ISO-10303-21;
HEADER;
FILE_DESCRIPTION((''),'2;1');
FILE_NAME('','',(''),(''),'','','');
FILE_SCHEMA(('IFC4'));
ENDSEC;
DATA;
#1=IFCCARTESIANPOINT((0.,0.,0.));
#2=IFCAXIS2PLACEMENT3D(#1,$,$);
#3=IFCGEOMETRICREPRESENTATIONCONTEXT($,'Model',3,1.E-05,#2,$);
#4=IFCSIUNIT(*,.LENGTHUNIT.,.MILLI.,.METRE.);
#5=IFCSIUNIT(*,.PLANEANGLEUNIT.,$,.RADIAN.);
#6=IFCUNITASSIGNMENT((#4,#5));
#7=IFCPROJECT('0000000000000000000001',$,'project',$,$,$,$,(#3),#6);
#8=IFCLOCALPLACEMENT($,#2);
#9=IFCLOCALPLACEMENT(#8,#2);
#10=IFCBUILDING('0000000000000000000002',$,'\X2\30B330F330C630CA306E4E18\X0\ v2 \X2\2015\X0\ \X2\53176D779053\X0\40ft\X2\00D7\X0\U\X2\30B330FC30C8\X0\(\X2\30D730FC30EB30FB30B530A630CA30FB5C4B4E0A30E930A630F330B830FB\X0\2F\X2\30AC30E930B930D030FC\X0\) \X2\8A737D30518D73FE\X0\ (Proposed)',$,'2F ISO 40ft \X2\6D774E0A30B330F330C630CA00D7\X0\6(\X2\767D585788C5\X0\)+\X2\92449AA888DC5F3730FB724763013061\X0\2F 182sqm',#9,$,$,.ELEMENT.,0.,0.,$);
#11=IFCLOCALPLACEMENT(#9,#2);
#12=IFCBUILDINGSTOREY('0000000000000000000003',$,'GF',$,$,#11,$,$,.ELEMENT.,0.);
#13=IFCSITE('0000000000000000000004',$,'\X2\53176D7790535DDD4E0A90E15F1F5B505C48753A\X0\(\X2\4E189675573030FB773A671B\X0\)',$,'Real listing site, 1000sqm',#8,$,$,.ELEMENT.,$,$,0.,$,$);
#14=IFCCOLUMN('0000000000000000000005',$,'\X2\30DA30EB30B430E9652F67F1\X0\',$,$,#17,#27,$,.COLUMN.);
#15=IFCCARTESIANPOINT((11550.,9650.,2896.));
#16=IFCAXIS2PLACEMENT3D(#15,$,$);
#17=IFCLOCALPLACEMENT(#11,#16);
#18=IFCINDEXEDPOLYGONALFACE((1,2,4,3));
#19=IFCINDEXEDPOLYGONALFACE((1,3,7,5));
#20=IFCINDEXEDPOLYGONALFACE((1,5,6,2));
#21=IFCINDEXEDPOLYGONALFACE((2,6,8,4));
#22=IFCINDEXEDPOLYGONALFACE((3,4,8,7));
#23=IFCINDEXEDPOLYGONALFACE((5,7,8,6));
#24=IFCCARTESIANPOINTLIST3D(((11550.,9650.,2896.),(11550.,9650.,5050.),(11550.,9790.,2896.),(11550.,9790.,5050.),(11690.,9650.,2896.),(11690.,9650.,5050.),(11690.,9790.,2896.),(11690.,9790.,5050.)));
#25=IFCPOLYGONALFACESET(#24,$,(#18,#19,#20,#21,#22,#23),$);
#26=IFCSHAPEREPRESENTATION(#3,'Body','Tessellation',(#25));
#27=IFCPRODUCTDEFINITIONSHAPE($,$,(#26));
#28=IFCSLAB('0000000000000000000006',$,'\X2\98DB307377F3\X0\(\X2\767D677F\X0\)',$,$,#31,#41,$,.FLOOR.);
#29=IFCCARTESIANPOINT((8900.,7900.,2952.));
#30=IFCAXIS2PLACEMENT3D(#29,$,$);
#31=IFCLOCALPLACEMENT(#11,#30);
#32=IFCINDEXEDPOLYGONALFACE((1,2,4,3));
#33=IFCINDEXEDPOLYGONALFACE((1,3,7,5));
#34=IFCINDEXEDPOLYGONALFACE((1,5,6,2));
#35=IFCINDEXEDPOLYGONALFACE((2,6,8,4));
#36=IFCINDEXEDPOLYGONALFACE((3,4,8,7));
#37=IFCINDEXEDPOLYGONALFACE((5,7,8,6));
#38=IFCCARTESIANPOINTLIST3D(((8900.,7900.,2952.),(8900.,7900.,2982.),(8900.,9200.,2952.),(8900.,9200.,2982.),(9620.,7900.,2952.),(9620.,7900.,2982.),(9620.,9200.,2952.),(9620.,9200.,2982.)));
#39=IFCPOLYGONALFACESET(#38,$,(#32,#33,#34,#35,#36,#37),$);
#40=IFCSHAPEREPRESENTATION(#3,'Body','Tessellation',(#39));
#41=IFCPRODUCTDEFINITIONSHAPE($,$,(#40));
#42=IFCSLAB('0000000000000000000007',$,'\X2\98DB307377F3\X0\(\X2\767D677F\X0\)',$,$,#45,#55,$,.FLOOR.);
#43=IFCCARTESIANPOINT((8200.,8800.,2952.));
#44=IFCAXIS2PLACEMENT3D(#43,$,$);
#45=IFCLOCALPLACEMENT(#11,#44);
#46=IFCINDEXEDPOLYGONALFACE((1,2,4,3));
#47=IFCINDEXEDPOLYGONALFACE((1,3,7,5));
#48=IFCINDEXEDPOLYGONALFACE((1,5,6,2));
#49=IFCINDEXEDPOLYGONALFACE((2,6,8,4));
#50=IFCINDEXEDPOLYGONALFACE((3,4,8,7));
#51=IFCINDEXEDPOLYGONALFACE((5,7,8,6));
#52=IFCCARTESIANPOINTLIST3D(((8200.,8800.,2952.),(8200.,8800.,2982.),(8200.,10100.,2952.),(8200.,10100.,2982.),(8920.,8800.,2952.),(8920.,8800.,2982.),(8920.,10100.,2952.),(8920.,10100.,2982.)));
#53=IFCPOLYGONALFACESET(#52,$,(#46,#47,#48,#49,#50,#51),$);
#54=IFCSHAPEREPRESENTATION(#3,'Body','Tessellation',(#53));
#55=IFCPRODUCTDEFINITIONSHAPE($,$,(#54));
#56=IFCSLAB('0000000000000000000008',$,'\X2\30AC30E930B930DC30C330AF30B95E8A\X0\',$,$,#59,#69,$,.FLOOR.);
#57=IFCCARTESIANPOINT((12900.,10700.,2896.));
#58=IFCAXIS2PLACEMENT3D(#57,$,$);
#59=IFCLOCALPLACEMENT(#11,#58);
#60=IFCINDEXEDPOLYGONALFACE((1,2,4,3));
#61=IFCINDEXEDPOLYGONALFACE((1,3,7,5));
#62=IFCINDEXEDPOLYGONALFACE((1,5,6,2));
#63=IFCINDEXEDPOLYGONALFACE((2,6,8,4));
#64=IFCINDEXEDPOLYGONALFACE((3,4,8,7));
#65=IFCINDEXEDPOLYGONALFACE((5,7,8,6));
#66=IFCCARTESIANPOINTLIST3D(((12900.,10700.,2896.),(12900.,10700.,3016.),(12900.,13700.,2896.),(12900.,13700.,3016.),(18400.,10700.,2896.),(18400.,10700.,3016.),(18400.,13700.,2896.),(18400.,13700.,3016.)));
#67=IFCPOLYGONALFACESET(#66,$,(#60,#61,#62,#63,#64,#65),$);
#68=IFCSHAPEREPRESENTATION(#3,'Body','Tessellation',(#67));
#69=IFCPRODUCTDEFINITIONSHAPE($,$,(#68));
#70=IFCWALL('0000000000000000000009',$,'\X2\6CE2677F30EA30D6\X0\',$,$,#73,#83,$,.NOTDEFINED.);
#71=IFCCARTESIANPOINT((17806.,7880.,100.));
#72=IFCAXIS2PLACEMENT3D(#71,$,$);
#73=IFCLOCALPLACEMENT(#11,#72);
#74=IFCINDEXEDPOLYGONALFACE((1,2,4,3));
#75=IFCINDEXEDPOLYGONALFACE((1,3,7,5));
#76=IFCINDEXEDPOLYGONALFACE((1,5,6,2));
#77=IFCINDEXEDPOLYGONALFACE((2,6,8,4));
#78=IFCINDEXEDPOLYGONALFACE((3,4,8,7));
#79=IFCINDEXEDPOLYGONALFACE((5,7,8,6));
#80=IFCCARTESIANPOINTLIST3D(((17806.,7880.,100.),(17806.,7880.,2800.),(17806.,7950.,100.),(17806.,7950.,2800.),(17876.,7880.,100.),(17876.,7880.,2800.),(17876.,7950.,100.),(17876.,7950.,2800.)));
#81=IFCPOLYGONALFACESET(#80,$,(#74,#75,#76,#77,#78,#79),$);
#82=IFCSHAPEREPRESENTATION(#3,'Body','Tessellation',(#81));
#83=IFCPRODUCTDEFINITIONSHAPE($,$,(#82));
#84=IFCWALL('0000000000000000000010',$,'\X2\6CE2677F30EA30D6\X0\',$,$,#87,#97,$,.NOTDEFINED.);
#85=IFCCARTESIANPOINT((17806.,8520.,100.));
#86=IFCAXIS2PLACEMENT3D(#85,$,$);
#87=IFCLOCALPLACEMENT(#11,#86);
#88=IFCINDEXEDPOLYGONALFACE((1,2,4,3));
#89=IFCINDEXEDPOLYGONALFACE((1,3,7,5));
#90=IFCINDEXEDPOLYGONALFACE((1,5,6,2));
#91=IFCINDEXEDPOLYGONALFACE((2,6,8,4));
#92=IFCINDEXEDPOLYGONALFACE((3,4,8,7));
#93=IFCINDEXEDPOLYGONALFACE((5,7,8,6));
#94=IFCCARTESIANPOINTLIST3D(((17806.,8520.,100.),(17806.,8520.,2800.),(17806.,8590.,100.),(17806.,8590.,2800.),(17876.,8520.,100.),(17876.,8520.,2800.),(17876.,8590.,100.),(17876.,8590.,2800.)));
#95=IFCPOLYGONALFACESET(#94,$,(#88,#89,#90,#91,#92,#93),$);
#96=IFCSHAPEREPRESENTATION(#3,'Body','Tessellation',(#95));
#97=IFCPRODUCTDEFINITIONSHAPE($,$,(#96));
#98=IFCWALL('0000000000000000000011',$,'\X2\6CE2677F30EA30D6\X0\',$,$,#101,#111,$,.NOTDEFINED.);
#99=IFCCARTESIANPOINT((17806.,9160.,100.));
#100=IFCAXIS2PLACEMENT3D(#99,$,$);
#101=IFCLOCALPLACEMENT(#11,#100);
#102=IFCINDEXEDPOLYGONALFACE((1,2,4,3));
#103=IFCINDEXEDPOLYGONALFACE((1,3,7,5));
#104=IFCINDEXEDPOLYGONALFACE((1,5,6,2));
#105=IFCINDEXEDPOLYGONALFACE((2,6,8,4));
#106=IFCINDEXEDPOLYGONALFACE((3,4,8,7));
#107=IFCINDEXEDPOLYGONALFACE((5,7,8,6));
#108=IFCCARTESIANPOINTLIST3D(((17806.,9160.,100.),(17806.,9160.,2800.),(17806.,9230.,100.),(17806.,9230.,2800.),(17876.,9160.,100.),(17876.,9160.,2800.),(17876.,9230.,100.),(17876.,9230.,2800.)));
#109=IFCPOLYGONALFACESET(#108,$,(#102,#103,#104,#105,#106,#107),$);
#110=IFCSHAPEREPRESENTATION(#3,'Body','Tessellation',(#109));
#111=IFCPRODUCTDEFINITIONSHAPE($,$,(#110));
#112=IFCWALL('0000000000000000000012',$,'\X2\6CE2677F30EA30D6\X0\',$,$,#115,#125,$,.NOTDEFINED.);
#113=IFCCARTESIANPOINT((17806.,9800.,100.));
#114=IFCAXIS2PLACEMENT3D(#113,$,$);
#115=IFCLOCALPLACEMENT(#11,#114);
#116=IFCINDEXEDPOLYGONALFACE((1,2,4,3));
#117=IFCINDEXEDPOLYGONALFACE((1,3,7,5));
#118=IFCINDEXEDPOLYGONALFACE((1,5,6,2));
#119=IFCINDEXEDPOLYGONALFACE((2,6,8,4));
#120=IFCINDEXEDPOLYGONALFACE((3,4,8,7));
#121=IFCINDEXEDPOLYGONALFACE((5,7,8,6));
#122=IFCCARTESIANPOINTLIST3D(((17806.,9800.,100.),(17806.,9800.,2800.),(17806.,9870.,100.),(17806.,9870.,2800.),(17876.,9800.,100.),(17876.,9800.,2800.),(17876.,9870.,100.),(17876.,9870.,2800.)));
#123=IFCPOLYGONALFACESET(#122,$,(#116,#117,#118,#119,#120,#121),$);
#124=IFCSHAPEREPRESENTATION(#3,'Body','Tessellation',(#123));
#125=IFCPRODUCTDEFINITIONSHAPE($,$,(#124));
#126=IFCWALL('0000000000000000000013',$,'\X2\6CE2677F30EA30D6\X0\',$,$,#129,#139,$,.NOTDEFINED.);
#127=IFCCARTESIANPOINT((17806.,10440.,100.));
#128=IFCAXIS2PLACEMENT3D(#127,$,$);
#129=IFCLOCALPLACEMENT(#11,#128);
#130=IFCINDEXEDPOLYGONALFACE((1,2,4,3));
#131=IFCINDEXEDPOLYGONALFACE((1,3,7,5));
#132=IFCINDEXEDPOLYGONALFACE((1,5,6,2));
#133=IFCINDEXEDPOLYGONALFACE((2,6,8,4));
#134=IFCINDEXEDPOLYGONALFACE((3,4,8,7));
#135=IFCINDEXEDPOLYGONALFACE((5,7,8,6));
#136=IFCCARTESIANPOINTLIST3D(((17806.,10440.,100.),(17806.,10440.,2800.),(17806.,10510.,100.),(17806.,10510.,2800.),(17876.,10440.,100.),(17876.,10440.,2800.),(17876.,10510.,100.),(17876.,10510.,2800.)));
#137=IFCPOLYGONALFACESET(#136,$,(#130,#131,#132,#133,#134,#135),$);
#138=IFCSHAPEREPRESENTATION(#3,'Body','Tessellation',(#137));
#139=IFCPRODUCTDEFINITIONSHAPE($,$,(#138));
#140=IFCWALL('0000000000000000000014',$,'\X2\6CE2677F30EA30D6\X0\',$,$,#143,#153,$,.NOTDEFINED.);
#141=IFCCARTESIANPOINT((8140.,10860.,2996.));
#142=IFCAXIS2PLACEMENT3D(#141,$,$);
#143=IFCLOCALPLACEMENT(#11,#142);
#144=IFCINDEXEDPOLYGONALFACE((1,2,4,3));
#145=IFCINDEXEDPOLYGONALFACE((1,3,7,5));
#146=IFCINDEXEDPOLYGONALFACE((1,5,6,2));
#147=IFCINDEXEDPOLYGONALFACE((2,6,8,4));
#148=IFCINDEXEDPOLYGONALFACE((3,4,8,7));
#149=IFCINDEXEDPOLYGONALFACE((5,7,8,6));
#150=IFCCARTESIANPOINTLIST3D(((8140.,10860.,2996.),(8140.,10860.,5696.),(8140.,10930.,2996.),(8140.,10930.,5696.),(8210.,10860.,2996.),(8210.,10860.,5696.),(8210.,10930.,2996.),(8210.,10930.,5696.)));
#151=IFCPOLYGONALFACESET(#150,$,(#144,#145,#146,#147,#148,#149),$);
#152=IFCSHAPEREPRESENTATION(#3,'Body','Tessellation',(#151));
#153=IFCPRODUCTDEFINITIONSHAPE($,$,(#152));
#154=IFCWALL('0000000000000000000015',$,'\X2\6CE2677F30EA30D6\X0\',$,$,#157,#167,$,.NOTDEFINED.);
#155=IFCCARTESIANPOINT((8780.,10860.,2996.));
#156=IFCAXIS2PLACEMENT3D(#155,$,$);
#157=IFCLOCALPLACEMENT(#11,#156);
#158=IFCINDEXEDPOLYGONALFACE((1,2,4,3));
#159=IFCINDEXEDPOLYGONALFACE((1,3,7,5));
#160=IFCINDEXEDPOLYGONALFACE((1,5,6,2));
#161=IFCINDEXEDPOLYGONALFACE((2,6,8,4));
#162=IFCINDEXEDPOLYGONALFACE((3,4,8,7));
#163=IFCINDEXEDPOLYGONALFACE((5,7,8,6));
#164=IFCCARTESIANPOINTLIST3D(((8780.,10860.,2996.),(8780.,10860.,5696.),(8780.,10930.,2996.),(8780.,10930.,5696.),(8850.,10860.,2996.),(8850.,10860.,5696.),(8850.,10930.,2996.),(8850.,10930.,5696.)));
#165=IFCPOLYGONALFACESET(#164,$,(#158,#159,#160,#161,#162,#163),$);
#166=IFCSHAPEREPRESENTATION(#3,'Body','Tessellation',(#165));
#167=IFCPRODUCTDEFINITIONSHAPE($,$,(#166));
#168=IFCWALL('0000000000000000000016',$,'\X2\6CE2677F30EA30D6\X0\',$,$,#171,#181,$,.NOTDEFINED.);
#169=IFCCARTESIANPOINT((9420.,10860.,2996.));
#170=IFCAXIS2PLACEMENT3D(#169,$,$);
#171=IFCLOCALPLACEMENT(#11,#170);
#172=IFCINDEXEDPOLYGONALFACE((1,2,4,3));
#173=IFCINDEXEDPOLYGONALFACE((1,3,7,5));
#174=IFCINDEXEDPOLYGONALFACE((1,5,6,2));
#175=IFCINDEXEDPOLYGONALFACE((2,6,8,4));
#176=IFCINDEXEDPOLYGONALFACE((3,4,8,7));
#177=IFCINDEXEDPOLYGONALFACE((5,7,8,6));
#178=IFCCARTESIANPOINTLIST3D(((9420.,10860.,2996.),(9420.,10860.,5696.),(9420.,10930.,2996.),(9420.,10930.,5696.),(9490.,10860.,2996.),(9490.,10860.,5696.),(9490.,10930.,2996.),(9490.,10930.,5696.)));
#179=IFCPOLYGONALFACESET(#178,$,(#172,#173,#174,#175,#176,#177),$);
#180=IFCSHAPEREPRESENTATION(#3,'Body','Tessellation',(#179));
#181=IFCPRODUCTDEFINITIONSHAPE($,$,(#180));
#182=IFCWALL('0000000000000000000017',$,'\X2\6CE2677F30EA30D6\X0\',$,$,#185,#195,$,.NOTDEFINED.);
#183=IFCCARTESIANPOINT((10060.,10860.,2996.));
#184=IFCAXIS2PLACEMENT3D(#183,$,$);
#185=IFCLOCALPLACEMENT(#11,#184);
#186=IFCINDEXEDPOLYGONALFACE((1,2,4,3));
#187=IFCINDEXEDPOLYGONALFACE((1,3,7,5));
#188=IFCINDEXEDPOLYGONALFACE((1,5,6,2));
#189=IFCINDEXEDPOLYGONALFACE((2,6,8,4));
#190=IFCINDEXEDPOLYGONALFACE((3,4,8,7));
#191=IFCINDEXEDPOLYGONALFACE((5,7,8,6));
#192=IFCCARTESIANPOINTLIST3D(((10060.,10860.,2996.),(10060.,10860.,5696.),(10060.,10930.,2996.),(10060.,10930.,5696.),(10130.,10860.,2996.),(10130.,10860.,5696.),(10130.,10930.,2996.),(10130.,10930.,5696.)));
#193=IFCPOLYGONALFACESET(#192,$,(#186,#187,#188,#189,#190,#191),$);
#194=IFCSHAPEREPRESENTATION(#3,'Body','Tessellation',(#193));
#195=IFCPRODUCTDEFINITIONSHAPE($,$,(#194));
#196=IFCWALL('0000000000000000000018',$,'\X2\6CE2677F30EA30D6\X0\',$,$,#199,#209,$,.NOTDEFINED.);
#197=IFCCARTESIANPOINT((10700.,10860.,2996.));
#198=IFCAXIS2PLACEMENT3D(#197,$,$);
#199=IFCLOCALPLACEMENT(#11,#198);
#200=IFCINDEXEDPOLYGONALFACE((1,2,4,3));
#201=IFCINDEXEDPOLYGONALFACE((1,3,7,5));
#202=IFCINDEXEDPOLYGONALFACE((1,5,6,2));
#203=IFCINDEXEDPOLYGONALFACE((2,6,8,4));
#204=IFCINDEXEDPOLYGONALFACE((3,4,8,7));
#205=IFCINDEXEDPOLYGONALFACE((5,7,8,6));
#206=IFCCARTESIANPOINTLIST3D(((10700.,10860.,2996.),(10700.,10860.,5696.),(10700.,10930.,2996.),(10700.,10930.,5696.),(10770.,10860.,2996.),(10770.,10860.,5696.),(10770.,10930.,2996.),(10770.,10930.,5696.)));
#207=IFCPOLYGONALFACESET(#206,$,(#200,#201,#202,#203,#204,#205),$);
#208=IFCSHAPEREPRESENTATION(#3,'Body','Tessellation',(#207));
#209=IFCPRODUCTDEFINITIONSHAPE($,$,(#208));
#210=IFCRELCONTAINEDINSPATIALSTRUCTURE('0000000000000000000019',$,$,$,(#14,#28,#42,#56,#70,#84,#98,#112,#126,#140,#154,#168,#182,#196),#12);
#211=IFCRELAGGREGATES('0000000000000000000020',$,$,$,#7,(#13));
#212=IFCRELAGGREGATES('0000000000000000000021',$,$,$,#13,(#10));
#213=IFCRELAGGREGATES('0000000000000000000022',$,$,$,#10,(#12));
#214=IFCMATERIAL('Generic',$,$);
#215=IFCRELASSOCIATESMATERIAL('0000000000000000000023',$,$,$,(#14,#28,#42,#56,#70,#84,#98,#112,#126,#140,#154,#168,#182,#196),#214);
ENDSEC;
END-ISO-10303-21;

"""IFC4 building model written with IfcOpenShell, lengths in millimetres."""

from ifc_helpers import new_model, si_unit, frame, frame_2d, origin, place, context, project, spatial, rectangle, extrude, material, element, save


model = new_model("IFC4")

# Units and contexts
model_context = context("Model", 3, precision=1e-05, world=origin())
ifc_project = project(units=[si_unit("LENGTHUNIT", "METRE", prefix="MILLI"), si_unit("PLANEANGLEUNIT", "RADIAN")], contexts=[model_context])

# Site, building, storey
site_placement = place(None, origin())
site = spatial("IfcSite", under=ifc_project, at=site_placement, Name="北海道川上郡弟子屈町(丘陵地・眺望)", ObjectType="Real listing site, 1000sqm", CompositionType="ELEMENT", RefElevation=0.0)
building_placement = place(site_placement, origin())
building = spatial("IfcBuilding", under=site, at=building_placement, Name="コンテナの丘 v2 ― 北海道40ft×Uコート(プール・サウナ・屋上ラウンジ・2Fガラスバー) 詳細再現 (Proposed)", ObjectType="2F ISO 40ft 海上コンテナ×6(白塗装)+鉄骨補強・片持ち2F 182sqm", CompositionType="ELEMENT", ElevationOfRefHeight=0.0, ElevationOfTerrain=0.0)
storey_placement = place(building_placement, origin())
storey = spatial("IfcBuildingStorey", under=building, at=storey_placement, Name="GF", CompositionType="ELEMENT", Elevation=0.0)

# Column
ifc_material = material(Name="Generic")
column_placement = place(storey_placement, frame((11550.0, 9650.0, 2896.0)))
element("IfcColumn", 1, at=column_placement, inside=storey, material=ifc_material, Name="ペルゴラ支柱", PredefinedType="COLUMN", context=model_context, shape_type="SweptSolid", body=[
    extrude(rectangle(XDim=140.0, YDim=140.0, at=frame_2d((70.0, 70.0))), frame((11550.0, 9650.0, 2896.0)), (0.0, 0.0, 1.0), 2154.0),
])

# Slabs
slab_1_placement = place(storey_placement, frame((8900.0, 7900.0, 2952.0)))
element("IfcSlab", 2, at=slab_1_placement, inside=storey, material=ifc_material, Name="飛び石(白板)", PredefinedType="FLOOR", context=model_context, shape_type="SweptSolid", body=[
    extrude(rectangle(XDim=720.0, YDim=1300.0, at=frame_2d((360.0, 650.0))), frame((8900.0, 7900.0, 2952.0)), (0.0, 0.0, 1.0), 30.0),
])
slab_2_placement = place(storey_placement, frame((8200.0, 8800.0, 2952.0)))
element("IfcSlab", 3, at=slab_2_placement, inside=storey, material=ifc_material, Name="飛び石(白板)", PredefinedType="FLOOR", context=model_context, shape_type="SweptSolid", body=[
    extrude(rectangle(XDim=720.0, YDim=1300.0, at=frame_2d((360.0, 650.0))), frame((8200.0, 8800.0, 2952.0)), (0.0, 0.0, 1.0), 30.0),
])
slab_3_placement = place(storey_placement, frame((12900.0, 10700.0, 2896.0)))
element("IfcSlab", 4, at=slab_3_placement, inside=storey, material=ifc_material, Name="ガラスボックス床", PredefinedType="FLOOR", context=model_context, shape_type="SweptSolid", body=[
    extrude(rectangle(XDim=5500.0, YDim=3000.0, at=frame_2d((2750.0, 1500.0))), frame((12900.0, 10700.0, 2896.0)), (0.0, 0.0, 1.0), 120.0),
])

# Walls
wall_1_placement = place(storey_placement, frame((17806.0, 7880.0, 100.0)))
element("IfcWall", 5, at=wall_1_placement, inside=storey, material=ifc_material, Name="波板リブ", PredefinedType="NOTDEFINED", context=model_context, shape_type="SweptSolid", body=[
    extrude(rectangle(XDim=70.0, YDim=70.0, at=frame_2d((35.0, 35.0))), frame((17806.0, 7880.0, 100.0)), (0.0, 0.0, 1.0), 2700.0),
])
wall_2_placement = place(storey_placement, frame((17806.0, 8520.0, 100.0)))
element("IfcWall", 6, at=wall_2_placement, inside=storey, material=ifc_material, Name="波板リブ", PredefinedType="NOTDEFINED", context=model_context, shape_type="SweptSolid", body=[
    extrude(rectangle(XDim=70.0, YDim=70.0, at=frame_2d((35.0, 35.0))), frame((17806.0, 8520.0, 100.0)), (0.0, 0.0, 1.0), 2700.0),
])
wall_3_placement = place(storey_placement, frame((17806.0, 9160.0, 100.0)))
element("IfcWall", 7, at=wall_3_placement, inside=storey, material=ifc_material, Name="波板リブ", PredefinedType="NOTDEFINED", context=model_context, shape_type="SweptSolid", body=[
    extrude(rectangle(XDim=70.0, YDim=70.0, at=frame_2d((35.0, 35.0))), frame((17806.0, 9160.0, 100.0)), (0.0, 0.0, 1.0), 2700.0),
])
wall_4_placement = place(storey_placement, frame((17806.0, 9800.0, 100.0)))
element("IfcWall", 8, at=wall_4_placement, inside=storey, material=ifc_material, Name="波板リブ", PredefinedType="NOTDEFINED", context=model_context, shape_type="SweptSolid", body=[
    extrude(rectangle(XDim=70.0, YDim=70.0, at=frame_2d((35.0, 35.0))), frame((17806.0, 9800.0, 100.0)), (0.0, 0.0, 1.0), 2700.0),
])
wall_5_placement = place(storey_placement, frame((17806.0, 10440.0, 100.0)))
element("IfcWall", 9, at=wall_5_placement, inside=storey, material=ifc_material, Name="波板リブ", PredefinedType="NOTDEFINED", context=model_context, shape_type="SweptSolid", body=[
    extrude(rectangle(XDim=70.0, YDim=70.0, at=frame_2d((35.0, 35.0))), frame((17806.0, 10440.0, 100.0)), (0.0, 0.0, 1.0), 2700.0),
])
wall_6_placement = place(storey_placement, frame((8140.0, 10860.0, 2996.0)))
element("IfcWall", 10, at=wall_6_placement, inside=storey, material=ifc_material, Name="波板リブ", PredefinedType="NOTDEFINED", context=model_context, shape_type="SweptSolid", body=[
    extrude(rectangle(XDim=70.0, YDim=70.0, at=frame_2d((35.0, 35.0))), frame((8140.0, 10860.0, 2996.0)), (0.0, 0.0, 1.0), 2700.0),
])
wall_7_placement = place(storey_placement, frame((8780.0, 10860.0, 2996.0)))
element("IfcWall", 11, at=wall_7_placement, inside=storey, material=ifc_material, Name="波板リブ", PredefinedType="NOTDEFINED", context=model_context, shape_type="SweptSolid", body=[
    extrude(rectangle(XDim=70.0, YDim=70.0, at=frame_2d((35.0, 35.0))), frame((8780.0, 10860.0, 2996.0)), (0.0, 0.0, 1.0), 2700.0),
])
wall_8_placement = place(storey_placement, frame((9420.0, 10860.0, 2996.0)))
element("IfcWall", 12, at=wall_8_placement, inside=storey, material=ifc_material, Name="波板リブ", PredefinedType="NOTDEFINED", context=model_context, shape_type="SweptSolid", body=[
    extrude(rectangle(XDim=70.0, YDim=70.0, at=frame_2d((35.0, 35.0))), frame((9420.0, 10860.0, 2996.0)), (0.0, 0.0, 1.0), 2700.0),
])
wall_9_placement = place(storey_placement, frame((10060.0, 10860.0, 2996.0)))
element("IfcWall", 13, at=wall_9_placement, inside=storey, material=ifc_material, Name="波板リブ", PredefinedType="NOTDEFINED", context=model_context, shape_type="SweptSolid", body=[
    extrude(rectangle(XDim=70.0, YDim=70.0, at=frame_2d((35.0, 35.0))), frame((10060.0, 10860.0, 2996.0)), (0.0, 0.0, 1.0), 2700.0),
])
wall_10_placement = place(storey_placement, frame((10700.0, 10860.0, 2996.0)))
element("IfcWall", 14, at=wall_10_placement, inside=storey, material=ifc_material, Name="波板リブ", PredefinedType="NOTDEFINED", context=model_context, shape_type="SweptSolid", body=[
    extrude(rectangle(XDim=70.0, YDim=70.0, at=frame_2d((35.0, 35.0))), frame((10700.0, 10860.0, 2996.0)), (0.0, 0.0, 1.0), 2700.0),
])

save(model, "model.ifc")
